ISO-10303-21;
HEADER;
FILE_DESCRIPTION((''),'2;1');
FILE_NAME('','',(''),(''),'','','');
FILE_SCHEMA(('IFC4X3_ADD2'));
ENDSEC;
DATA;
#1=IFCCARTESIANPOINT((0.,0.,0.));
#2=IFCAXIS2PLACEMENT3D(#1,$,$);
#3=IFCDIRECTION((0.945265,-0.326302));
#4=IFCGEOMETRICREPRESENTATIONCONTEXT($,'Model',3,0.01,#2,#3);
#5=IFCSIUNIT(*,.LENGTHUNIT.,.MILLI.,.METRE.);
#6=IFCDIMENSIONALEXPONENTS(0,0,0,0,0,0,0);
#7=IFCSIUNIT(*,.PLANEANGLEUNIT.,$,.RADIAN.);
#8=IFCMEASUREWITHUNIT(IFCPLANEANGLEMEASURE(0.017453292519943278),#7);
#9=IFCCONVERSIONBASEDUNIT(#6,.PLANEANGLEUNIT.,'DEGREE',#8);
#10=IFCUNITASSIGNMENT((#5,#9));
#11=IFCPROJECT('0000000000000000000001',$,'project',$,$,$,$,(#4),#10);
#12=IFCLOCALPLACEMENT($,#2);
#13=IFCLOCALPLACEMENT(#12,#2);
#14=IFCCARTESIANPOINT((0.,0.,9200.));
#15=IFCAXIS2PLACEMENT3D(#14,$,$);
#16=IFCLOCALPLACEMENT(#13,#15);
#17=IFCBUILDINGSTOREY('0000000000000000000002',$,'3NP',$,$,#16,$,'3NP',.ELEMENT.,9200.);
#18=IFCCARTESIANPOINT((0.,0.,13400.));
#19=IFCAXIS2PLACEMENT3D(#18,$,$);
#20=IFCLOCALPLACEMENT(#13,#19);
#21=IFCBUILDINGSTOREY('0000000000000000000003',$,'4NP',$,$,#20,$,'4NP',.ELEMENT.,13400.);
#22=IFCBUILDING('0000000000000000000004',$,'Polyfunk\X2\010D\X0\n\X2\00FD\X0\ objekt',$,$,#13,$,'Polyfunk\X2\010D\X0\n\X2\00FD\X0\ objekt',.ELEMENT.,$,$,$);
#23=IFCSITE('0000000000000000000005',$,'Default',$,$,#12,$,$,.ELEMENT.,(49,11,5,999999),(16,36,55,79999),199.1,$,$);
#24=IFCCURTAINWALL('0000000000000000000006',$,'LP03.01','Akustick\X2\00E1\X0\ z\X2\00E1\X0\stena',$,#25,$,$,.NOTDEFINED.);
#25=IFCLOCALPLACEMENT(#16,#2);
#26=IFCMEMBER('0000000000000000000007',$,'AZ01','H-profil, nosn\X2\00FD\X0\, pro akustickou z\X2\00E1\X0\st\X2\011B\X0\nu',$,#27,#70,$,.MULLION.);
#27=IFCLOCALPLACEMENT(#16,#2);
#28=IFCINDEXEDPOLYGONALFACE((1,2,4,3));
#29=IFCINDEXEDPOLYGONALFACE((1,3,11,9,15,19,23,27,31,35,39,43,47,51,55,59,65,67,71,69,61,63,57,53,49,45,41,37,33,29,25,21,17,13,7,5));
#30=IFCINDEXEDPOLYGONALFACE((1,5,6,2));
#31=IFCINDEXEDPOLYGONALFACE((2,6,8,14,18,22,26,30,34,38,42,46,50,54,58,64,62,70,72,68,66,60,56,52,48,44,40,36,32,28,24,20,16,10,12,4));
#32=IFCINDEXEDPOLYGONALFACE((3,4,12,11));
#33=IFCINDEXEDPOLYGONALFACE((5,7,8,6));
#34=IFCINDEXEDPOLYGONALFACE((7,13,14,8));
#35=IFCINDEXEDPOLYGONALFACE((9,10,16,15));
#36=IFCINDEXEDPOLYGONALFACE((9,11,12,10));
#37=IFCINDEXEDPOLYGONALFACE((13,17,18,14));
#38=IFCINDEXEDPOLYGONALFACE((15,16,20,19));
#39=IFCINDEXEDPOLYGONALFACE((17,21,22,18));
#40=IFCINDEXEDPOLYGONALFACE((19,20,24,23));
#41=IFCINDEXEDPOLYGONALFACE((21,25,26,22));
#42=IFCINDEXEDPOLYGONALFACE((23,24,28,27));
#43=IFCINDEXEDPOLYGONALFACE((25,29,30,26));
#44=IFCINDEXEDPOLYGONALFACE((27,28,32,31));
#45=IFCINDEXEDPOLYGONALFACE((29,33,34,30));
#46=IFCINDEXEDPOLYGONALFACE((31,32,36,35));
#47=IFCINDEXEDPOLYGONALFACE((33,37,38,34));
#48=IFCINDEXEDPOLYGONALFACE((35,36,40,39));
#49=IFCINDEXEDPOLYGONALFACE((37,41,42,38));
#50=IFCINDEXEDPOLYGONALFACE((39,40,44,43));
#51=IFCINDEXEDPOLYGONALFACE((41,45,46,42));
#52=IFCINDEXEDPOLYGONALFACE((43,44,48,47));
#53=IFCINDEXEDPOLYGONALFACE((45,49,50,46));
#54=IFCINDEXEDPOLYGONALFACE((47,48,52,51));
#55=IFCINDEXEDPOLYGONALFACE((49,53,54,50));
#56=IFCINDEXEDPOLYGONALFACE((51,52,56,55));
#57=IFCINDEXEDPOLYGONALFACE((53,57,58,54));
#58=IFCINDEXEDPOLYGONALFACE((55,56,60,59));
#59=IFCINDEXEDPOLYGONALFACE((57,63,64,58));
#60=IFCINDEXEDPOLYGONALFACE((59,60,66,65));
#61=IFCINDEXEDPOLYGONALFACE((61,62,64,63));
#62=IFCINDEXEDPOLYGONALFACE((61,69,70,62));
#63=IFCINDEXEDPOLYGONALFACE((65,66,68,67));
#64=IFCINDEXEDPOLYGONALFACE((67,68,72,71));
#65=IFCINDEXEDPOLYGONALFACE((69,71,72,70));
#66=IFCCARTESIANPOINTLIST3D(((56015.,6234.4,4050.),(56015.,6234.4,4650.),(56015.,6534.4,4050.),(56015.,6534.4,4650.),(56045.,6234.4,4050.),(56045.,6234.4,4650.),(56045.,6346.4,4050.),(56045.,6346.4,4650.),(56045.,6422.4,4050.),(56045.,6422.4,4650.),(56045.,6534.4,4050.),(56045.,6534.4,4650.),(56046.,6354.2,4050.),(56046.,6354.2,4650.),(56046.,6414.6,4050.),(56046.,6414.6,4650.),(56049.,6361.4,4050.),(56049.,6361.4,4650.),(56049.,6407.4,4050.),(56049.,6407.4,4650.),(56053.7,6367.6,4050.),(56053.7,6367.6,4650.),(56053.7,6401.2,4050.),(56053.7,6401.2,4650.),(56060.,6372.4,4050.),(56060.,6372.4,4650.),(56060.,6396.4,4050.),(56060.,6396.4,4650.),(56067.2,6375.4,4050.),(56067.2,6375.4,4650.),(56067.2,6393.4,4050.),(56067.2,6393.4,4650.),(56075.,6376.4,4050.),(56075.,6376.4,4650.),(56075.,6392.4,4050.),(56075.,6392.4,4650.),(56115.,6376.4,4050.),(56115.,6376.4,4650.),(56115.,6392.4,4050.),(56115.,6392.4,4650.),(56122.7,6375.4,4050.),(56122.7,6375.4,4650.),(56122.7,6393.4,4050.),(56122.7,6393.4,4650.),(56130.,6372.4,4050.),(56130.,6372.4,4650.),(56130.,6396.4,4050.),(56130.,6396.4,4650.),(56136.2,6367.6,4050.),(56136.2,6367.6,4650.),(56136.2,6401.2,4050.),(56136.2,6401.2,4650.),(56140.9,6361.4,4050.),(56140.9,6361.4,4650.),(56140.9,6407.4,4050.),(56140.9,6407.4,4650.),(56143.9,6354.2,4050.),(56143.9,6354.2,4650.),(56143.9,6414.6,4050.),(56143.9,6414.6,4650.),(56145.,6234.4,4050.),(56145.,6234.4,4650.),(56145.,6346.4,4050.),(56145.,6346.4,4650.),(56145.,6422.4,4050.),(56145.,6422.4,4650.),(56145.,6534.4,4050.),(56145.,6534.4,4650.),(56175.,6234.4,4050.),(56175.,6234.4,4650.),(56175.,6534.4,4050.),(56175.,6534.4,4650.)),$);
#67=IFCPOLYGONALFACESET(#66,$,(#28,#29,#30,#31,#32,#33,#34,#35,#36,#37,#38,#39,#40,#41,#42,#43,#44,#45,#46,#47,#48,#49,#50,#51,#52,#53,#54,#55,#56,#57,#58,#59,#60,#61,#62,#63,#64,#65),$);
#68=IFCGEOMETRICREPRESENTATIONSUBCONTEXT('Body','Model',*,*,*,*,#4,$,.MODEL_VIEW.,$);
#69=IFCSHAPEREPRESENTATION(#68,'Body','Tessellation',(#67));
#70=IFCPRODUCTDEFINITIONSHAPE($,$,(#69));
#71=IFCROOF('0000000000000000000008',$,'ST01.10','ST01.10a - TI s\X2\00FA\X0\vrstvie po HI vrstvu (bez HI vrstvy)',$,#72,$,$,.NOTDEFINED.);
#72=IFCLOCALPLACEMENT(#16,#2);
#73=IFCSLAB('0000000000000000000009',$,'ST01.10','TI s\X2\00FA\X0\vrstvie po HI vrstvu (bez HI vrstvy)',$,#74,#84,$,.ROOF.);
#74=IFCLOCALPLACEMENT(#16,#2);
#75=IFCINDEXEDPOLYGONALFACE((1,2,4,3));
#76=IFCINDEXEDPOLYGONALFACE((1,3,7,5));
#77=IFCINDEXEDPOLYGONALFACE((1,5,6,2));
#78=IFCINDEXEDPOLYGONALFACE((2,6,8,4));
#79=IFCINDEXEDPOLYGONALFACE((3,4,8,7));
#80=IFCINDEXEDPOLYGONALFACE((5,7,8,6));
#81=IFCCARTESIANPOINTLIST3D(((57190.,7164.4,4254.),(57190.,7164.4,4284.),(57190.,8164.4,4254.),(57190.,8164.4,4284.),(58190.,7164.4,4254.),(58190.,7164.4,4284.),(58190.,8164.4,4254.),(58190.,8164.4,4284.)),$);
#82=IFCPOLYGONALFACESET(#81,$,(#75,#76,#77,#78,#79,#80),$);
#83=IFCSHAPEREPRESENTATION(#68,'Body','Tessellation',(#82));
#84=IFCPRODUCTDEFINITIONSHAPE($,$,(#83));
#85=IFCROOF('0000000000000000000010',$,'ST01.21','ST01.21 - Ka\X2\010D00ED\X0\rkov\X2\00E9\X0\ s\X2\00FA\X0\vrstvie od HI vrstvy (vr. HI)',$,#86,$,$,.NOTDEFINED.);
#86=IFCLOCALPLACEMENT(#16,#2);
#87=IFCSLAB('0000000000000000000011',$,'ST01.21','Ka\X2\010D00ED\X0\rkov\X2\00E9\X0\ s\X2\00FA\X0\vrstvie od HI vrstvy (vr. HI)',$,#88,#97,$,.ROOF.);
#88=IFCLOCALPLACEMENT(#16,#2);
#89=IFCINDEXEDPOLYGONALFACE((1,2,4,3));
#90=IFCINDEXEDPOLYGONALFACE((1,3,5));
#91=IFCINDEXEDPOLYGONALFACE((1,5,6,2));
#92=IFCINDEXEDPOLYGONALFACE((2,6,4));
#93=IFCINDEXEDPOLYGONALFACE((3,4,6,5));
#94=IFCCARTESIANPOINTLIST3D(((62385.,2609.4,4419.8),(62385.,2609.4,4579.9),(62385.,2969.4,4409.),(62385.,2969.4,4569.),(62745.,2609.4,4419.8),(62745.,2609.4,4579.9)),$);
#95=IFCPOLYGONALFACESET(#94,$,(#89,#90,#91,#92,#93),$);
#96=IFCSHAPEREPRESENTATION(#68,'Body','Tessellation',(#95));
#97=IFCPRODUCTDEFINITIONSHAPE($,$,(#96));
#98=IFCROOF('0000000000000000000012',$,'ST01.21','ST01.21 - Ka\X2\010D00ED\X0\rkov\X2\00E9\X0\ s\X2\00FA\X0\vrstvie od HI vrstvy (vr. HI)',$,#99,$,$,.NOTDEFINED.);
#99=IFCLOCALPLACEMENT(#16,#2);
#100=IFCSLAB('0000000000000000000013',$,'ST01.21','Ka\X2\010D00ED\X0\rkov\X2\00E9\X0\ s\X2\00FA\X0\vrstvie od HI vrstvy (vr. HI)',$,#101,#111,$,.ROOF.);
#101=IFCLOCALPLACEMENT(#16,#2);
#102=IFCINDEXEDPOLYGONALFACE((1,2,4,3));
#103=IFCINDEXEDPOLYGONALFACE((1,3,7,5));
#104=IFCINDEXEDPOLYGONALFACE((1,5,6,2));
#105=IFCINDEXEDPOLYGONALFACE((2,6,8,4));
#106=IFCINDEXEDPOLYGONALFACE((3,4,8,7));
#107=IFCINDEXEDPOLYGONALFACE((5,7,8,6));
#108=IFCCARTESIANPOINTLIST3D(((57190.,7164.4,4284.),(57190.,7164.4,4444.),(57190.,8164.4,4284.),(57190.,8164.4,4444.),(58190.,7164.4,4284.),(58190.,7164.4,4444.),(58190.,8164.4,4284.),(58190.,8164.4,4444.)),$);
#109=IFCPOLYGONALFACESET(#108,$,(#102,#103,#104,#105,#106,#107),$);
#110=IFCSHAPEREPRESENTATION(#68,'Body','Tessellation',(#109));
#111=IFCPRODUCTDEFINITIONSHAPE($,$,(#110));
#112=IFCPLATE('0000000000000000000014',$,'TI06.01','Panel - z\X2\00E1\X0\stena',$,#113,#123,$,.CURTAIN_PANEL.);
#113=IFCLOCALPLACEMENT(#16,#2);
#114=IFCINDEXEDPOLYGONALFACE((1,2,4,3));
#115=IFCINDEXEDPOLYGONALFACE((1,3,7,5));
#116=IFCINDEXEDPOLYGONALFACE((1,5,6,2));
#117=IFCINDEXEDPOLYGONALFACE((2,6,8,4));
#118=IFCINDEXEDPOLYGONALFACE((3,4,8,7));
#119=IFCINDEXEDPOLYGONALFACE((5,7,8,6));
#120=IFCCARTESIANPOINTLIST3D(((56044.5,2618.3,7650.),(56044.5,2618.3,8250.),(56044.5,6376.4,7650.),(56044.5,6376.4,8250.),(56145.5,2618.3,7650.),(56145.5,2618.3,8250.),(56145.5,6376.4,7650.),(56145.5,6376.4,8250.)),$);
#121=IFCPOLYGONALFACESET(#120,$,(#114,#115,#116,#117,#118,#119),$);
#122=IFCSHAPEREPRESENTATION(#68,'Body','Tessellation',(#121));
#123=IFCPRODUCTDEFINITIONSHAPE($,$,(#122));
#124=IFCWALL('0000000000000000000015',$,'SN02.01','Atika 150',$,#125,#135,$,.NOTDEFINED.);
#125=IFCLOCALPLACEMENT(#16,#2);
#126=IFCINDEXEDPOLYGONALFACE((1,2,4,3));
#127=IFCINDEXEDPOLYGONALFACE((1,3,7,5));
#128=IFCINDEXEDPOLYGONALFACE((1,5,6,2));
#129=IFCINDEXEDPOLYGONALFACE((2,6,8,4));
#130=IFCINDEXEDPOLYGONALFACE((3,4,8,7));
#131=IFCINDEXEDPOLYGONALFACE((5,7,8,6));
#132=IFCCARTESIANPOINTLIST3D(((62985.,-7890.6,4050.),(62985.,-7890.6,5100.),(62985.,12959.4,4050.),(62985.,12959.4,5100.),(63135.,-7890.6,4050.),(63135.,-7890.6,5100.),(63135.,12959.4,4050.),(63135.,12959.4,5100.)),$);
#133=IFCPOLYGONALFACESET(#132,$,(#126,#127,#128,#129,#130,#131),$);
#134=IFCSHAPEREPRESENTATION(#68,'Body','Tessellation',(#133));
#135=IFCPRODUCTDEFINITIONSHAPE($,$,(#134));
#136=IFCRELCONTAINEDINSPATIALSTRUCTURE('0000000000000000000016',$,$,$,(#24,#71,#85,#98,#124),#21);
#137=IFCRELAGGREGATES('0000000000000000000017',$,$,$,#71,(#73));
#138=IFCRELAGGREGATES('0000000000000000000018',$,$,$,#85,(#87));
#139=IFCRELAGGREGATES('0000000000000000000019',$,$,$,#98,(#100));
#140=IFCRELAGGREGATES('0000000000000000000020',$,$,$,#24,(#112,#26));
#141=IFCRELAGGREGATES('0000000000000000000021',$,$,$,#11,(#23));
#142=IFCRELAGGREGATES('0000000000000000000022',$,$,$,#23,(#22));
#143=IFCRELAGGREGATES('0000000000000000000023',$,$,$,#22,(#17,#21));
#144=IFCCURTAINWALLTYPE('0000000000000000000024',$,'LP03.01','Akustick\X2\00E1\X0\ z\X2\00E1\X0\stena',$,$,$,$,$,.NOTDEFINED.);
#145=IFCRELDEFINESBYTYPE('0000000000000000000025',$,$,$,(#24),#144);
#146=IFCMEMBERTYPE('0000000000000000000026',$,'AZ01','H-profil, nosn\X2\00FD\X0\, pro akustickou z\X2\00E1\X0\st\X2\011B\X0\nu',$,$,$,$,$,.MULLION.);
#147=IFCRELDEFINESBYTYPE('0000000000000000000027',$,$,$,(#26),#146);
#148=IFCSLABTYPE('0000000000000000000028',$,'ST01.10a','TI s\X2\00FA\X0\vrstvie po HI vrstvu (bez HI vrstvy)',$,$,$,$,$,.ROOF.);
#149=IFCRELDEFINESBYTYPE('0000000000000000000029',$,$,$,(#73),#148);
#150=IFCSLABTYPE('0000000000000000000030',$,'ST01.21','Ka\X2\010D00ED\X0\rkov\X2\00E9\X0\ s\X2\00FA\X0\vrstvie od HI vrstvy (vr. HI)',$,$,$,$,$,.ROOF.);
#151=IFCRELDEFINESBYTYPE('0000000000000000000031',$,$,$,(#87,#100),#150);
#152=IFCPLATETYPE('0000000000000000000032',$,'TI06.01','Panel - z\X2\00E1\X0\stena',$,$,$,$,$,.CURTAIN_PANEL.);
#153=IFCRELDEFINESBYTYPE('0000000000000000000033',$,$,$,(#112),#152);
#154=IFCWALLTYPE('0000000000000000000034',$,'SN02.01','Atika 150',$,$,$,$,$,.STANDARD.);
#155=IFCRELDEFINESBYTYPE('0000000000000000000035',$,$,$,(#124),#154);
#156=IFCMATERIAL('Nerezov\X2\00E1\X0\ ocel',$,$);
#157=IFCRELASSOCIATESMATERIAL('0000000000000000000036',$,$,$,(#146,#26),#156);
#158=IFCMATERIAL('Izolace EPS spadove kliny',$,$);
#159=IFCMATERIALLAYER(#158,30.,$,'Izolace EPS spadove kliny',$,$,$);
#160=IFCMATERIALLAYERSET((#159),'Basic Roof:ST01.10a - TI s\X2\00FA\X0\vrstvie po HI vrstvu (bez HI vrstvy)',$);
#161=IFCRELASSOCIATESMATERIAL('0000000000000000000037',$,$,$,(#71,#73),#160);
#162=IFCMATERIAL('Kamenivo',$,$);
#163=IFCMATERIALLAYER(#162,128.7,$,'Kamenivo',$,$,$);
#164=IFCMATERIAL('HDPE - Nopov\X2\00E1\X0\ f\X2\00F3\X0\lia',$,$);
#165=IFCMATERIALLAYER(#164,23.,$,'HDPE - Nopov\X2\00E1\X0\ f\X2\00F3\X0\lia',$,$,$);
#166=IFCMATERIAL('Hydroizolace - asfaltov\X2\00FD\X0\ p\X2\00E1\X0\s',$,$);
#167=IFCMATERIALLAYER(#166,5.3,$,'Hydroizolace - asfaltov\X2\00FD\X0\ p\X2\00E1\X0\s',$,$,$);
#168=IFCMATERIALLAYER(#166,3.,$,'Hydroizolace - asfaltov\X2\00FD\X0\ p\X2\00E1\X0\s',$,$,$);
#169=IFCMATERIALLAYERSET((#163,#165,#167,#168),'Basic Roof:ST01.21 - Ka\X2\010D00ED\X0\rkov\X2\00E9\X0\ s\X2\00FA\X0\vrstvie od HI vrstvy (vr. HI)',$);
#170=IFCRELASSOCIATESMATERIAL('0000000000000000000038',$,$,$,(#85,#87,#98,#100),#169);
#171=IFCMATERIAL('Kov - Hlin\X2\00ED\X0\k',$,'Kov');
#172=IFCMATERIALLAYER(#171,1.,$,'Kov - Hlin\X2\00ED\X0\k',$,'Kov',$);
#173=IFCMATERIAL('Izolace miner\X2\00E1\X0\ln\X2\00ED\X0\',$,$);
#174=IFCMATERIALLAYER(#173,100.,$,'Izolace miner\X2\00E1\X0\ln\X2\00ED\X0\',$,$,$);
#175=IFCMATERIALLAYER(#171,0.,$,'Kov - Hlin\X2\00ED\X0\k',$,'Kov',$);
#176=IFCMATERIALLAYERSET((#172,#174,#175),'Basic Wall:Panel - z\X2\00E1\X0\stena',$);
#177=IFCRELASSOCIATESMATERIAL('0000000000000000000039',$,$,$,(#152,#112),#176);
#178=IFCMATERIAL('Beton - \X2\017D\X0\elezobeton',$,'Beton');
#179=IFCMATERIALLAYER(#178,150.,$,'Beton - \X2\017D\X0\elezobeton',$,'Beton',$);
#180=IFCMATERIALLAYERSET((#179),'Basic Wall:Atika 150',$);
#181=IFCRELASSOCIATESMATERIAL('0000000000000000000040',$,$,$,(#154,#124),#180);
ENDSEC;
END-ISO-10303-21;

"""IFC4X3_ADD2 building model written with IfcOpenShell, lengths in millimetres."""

from ifc_helpers import new_model, entity, si_unit, converted_unit, direction, frame, frame_2d, origin, place, context, subcontext, project, spatial, polyline, circle_curve, parameter, trimmed, segment, composite_curve, rectangle, outline, extrude, source, transform, mapped, material, layer, layer_set, layer_usage, material_profile, profile_set, profile_usage, type_object, element, aggregate, save


model = new_model("IFC4X3_ADD2")

# Units and contexts
model_context = context("Model", 3, precision=0.01, world=origin(), true_north=direction((0.945265, -0.326302)))
body_context = subcontext(model_context, "Body", "Model", "MODEL_VIEW")
ifc_project = project(units=[si_unit("LENGTHUNIT", "METRE", prefix="MILLI"), converted_unit("PLANEANGLEUNIT", "DEGREE", entity("IfcPlaneAngleMeasure", 0.017453292519943278), si_unit("PLANEANGLEUNIT", "RADIAN"), dimensions=[0, 0, 0, 0, 0, 0, 0])], contexts=[model_context])

# Site, building, storey
site_placement = place(None, origin())
site = spatial("IfcSite", under=ifc_project, at=site_placement, Name="Default", CompositionType="ELEMENT", RefLatitude=(49, 11, 5, 999999), RefLongitude=(16, 36, 55, 79999), RefElevation=199.1)
building_placement = place(site_placement, origin())
building = spatial("IfcBuilding", under=site, at=building_placement, Name="Polyfunkčný objekt", LongName="Polyfunkčný objekt", CompositionType="ELEMENT")
storey_1_placement = place(building_placement, frame((0.0, 0.0, 9200.0)))
storey_1 = spatial("IfcBuildingStorey", under=building, at=storey_1_placement, Name="3NP", LongName="3NP", CompositionType="ELEMENT", Elevation=9200.0)

# Shared definitions
storey_2_placement = place(building_placement, frame((0.0, 0.0, 13400.0)))
storey_2 = spatial("IfcBuildingStorey", under=building, at=storey_2_placement, Name="4NP", LongName="4NP", CompositionType="ELEMENT", Elevation=13400.0)

# Curtain wall, member
curtain_wall_type_1 = type_object("IfcCurtainWallType", Name="LP03.01", Description="Akustická zástena", PredefinedType="NOTDEFINED")
ifc_material_1 = material(Name="Nerezová ocel")
ifc_material_profile_1 = material_profile(ifc_material_1, outline(composite_curve([segment(polyline([(50.0, -150.0), (80.0, -150.0)]), True, "CONTINUOUS"), segment(polyline([(80.0, -150.0), (80.0, 150.0)]), True, "CONTINUOUS"), segment(polyline([(80.0, 150.0), (50.0, 150.0)]), True, "CONTINUOUS"), segment(polyline([(50.0, 150.0), (50.0, 38.0)]), True, "CONTINUOUS"), segment(trimmed(circle_curve(frame_2d((20.0, 38.0), x_axis=(0.0, 1.0)), 30.0), [parameter(180.0)], [parameter(270.0)], True, "PARAMETER"), False, "CONTINUOUS"), segment(polyline([(20.0, 8.0), (-20.0, 8.0)]), True, "CONTINUOUS"), segment(trimmed(circle_curve(frame_2d((-20.0, 38.0), x_axis=(0.0, 1.0)), 30.0), [parameter(90.0)], [parameter(180.0)], True, "PARAMETER"), False, "CONTINUOUS"), segment(polyline([(-50.0, 38.0), (-50.0, 150.0)]), True, "CONTINUOUS"), segment(polyline([(-50.0, 150.0), (-80.0, 150.0)]), True, "CONTINUOUS"), segment(polyline([(-80.0, 150.0), (-80.0, -150.0)]), True, "CONTINUOUS"), segment(polyline([(-80.0, -150.0), (-50.0, -150.0)]), True, "CONTINUOUS"), segment(polyline([(-50.0, -150.0), (-50.0, -38.0)]), True, "CONTINUOUS"), segment(trimmed(circle_curve(frame_2d((-20.0, -38.0), x_axis=(0.0, 1.0)), 30.0), [parameter(0.0)], [parameter(90.0)], True, "PARAMETER"), False, "CONTINUOUS"), segment(polyline([(-20.0, -8.0), (20.0, -8.0)]), True, "CONTINUOUS"), segment(trimmed(circle_curve(frame_2d((20.0, -38.0), x_axis=(0.0, 1.0)), 30.0), [parameter(270.0)], [parameter(0.0)], True, "PARAMETER"), False, "CONTINUOUS"), segment(polyline([(50.0, -38.0), (50.0, -150.0)]), True, "CONTINUOUS")], self_intersect=False)), Name="Profil zástena")
ifc_profile_set_1 = profile_set([ifc_material_profile_1], Name="Profil zástena")
ifc_profile_usage_1 = profile_usage(ifc_profile_set_1)
member_type_1 = type_object("IfcMemberType", Name="AZ01", Description="H-profil, nosný, pro akustickou zástěnu", PredefinedType="MULLION", material=ifc_profile_set_1)
curtain_wall_1_placement = place(storey_2_placement, frame((0.0, 0.0, -13400.0)))
curtain_wall_1 = element("IfcCurtainWall", 1, at=curtain_wall_1_placement, inside=storey_2, type_object=curtain_wall_type_1, Name="LP03.01", Description="Akustická zástena", PredefinedType="NOTDEFINED")
shared_shape_1 = source(origin(), body_context, "Body", "SweptSolid", [
    extrude(outline(composite_curve([segment(polyline([(-150.0, -50.0), (-150.0, -80.0)]), True, "CONTINUOUS"), segment(polyline([(-150.0, -80.0), (150.0, -80.0)]), True, "CONTINUOUS"), segment(polyline([(150.0, -80.0), (150.0, -50.0)]), True, "CONTINUOUS"), segment(polyline([(150.0, -50.0), (38.0, -50.0)]), True, "CONTINUOUS"), segment(trimmed(circle_curve(frame_2d((38.0, -20.0), x_axis=(1.0, 0.0)), 30.0), [parameter(180.0)], [parameter(270.0)], True, "PARAMETER"), False, "CONTINUOUS"), segment(polyline([(8.0, -20.0), (8.0, 20.0)]), True, "CONTINUOUS"), segment(trimmed(circle_curve(frame_2d((38.0, 20.0), x_axis=(1.0, 0.0)), 30.0), [parameter(90.0)], [parameter(180.0)], True, "PARAMETER"), False, "CONTINUOUS"), segment(polyline([(38.0, 50.0), (150.0, 50.0)]), True, "CONTINUOUS"), segment(polyline([(150.0, 50.0), (150.0, 80.0)]), True, "CONTINUOUS"), segment(polyline([(150.0, 80.0), (-150.0, 80.0)]), True, "CONTINUOUS"), segment(polyline([(-150.0, 80.0), (-150.0, 50.0)]), True, "CONTINUOUS"), segment(polyline([(-150.0, 50.0), (-38.0, 50.0)]), True, "CONTINUOUS"), segment(trimmed(circle_curve(frame_2d((-38.0, 20.0), x_axis=(1.0, 0.0)), 30.0), [parameter(0.0)], [parameter(90.0)], True, "PARAMETER"), False, "CONTINUOUS"), segment(polyline([(-8.0, 20.0), (-8.0, -20.0)]), True, "CONTINUOUS"), segment(trimmed(circle_curve(frame_2d((-38.0, -20.0), x_axis=(1.0, 0.0)), 30.0), [parameter(270.0)], [parameter(0.0)], True, "PARAMETER"), False, "CONTINUOUS"), segment(polyline([(-38.0, -50.0), (-150.0, -50.0)]), True, "CONTINUOUS")], self_intersect=False)), frame((-150.0, 0.0, -600.0), z_axis=(0.0, 0.0, -1.0), x_axis=(1.0, 0.0, 0.0)), (0.0, 0.0, -1.0), 600.0),
])
member_1_placement = place(curtain_wall_1_placement, frame((56095.0, 6534.4, 13250.0), z_axis=(0.0, 0.0, -1.0), x_axis=(0.0, 1.0, 0.0)))
member_1 = element("IfcMember", 2, at=member_1_placement, type_object=member_type_1, material=ifc_profile_usage_1, Name="AZ01", Description="H-profil, nosný, pro akustickou zástěnu", PredefinedType="MULLION", context=body_context, shape_type="MappedRepresentation", body=[
    mapped(shared_shape_1, transform((0.0, 0.0, 0.0), scale=1.0)),
])

# Roofs, slabs
ifc_material_2 = material(Name="Izolace EPS spadove kliny")
ifc_layer_1 = layer(ifc_material_2, 30.0, Name="Izolace EPS spadove kliny")
ifc_layer_set_1 = layer_set([ifc_layer_1], Name="Basic Roof:ST01.10a - TI súvrstvie po HI vrstvu (bez HI vrstvy)")
roof_1_placement = place(storey_2_placement, frame((57190.0, 7164.4, 54.0)))
roof_1 = element("IfcRoof", 3, at=roof_1_placement, inside=storey_2, material=ifc_layer_set_1, Name="ST01.10", Description="ST01.10a - TI súvrstvie po HI vrstvu (bez HI vrstvy)", PredefinedType="NOTDEFINED")
slab_type_1 = type_object("IfcSlabType", Name="ST01.10a", Description="TI súvrstvie po HI vrstvu (bez HI vrstvy)", PredefinedType="ROOF")
slab_1_placement = place(roof_1_placement, origin())
slab_1 = element("IfcSlab", 4, at=slab_1_placement, type_object=slab_type_1, material=ifc_layer_set_1, Name="ST01.10", Description="TI súvrstvie po HI vrstvu (bez HI vrstvy)", PredefinedType="ROOF", context=body_context, shape_type="SweptSolid", body=[
    extrude(rectangle(XDim=1000.0, YDim=1000.0, at=frame_2d((0.0, 0.0), x_axis=(1.0, 0.0))), frame((500.0, 500.0, 0.0)), (0.0, 0.0, 1.0), 30.0),
])
aggregate(roof_1, [slab_1])
ifc_material_3 = material(Name="Kamenivo")
ifc_layer_2 = layer(ifc_material_3, 128.7, Name="Kamenivo")
ifc_material_4 = material(Name="HDPE - Nopová fólia")
ifc_layer_3 = layer(ifc_material_4, 23.0, Name="HDPE - Nopová fólia")
ifc_material_5 = material(Name="Hydroizolace - asfaltový pás")
ifc_layer_4 = layer(ifc_material_5, 5.3, Name="Hydroizolace - asfaltový pás")
ifc_layer_5 = layer(ifc_material_5, 3.0, Name="Hydroizolace - asfaltový pás")
ifc_layer_set_2 = layer_set([ifc_layer_2, ifc_layer_3, ifc_layer_4, ifc_layer_5], Name="Basic Roof:ST01.21 - Kačírkové súvrstvie od HI vrstvy (vr. HI)")
roof_2_placement = place(storey_2_placement, frame((62385.0, 2609.4, 209.0)))
roof_2 = element("IfcRoof", 5, at=roof_2_placement, inside=storey_2, material=ifc_layer_set_2, Name="ST01.21", Description="ST01.21 - Kačírkové súvrstvie od HI vrstvy (vr. HI)", PredefinedType="NOTDEFINED")
slab_type_2 = type_object("IfcSlabType", Name="ST01.21", Description="Kačírkové súvrstvie od HI vrstvy (vr. HI)", PredefinedType="ROOF")
slab_2_placement = place(roof_2_placement, origin())
slab_2 = element("IfcSlab", 6, at=slab_2_placement, type_object=slab_type_2, material=ifc_layer_set_2, Name="ST01.21", Description="Kačírkové súvrstvie od HI vrstvy (vr. HI)", PredefinedType="ROOF", context=body_context, shape_type="SweptSolid", body=[
    extrude(outline(polyline([(180.0, -180.1), (-180.0, 180.1), (-180.0, -180.1), (180.0, -180.1)])), frame((180.0, 180.0, 5.4), z_axis=(0.0, 0.030015, 0.999549), x_axis=(1.0, 0.0, 0.0)), (0.0, -0.030015, 0.999549), 160.1),
])
aggregate(roof_2, [slab_2])
roof_3_placement = place(storey_2_placement, frame((57190.0, 7164.4, 84.0)))
roof_3 = element("IfcRoof", 7, at=roof_3_placement, inside=storey_2, material=ifc_layer_set_2, Name="ST01.21", Description="ST01.21 - Kačírkové súvrstvie od HI vrstvy (vr. HI)", PredefinedType="NOTDEFINED")
slab_3_placement = place(roof_3_placement, origin())
slab_3 = element("IfcSlab", 8, at=slab_3_placement, type_object=slab_type_2, material=ifc_layer_set_2, Name="ST01.21", Description="Kačírkové súvrstvie od HI vrstvy (vr. HI)", PredefinedType="ROOF", context=body_context, shape_type="SweptSolid", body=[
    extrude(rectangle(XDim=1000.0, YDim=1000.0, at=frame_2d((0.0, 0.0), x_axis=(1.0, 0.0))), frame((500.0, 500.0, 0.0)), (0.0, 0.0, 1.0), 160.0),
])
aggregate(roof_3, [slab_3])

# Plate
ifc_material_6 = material(Name="Kov - Hliník", Category="Kov")
ifc_layer_6 = layer(ifc_material_6, 1.0, Name="Kov - Hliník", Category="Kov")
ifc_material_7 = material(Name="Izolace minerální")
ifc_layer_7 = layer(ifc_material_7, 100.0, Name="Izolace minerální")
ifc_layer_8 = layer(ifc_material_6, 0.0, Name="Kov - Hliník", Category="Kov")
ifc_layer_set_3 = layer_set([ifc_layer_6, ifc_layer_7, ifc_layer_8], Name="Basic Wall:Panel - zástena")
ifc_layer_usage = layer_usage(ifc_layer_set_3, "AXIS2", "NEGATIVE", 50.5)
plate_type = type_object("IfcPlateType", Name="TI06.01", Description="Panel - zástena", PredefinedType="CURTAIN_PANEL", material=ifc_layer_set_3)
plate_placement = place(storey_2_placement, frame((56095.0, 2618.3, 3450.0), z_axis=(0.0, 0.0, 1.0), x_axis=(0.0, 1.0, 0.0)))
plate = element("IfcPlate", 9, at=plate_placement, type_object=plate_type, material=ifc_layer_usage, Name="TI06.01", Description="Panel - zástena", PredefinedType="CURTAIN_PANEL", context=body_context, shape_type="SweptSolid", body=[
    extrude(rectangle(XDim=101.0, YDim=3758.1, at=frame_2d((0.0, 0.0), x_axis=(1.0, 0.0))), frame((1879.0, 0.0, 0.0), z_axis=(0.0, 0.0, 1.0), x_axis=(0.0, 1.0, 0.0)), (0.0, 0.0, 1.0), 600.0),
])
aggregate(curtain_wall_1, [plate, member_1])

# Wall
ifc_material_8 = material(Name="Beton - Železobeton", Category="Beton")
ifc_layer_9 = layer(ifc_material_8, 150.0, Name="Beton - Železobeton", Category="Beton")
ifc_layer_set_4 = layer_set([ifc_layer_9], Name="Basic Wall:Atika 150")
wall_type = type_object("IfcWallType", Name="SN02.01", Description="Atika 150", PredefinedType="STANDARD", material=ifc_layer_set_4)
wall_placement = place(storey_2_placement, frame((63060.0, 12959.4, -150.0), z_axis=(0.0, 0.0, 1.0), x_axis=(0.0, -1.0, 0.0)))
element("IfcWall", 10, at=wall_placement, inside=storey_2, type_object=wall_type, material=ifc_layer_set_4, Name="SN02.01", Description="Atika 150", PredefinedType="NOTDEFINED", context=body_context, shape_type="SweptSolid", body=[
    extrude(rectangle(XDim=20850.0, YDim=150.0, at=frame_2d((10425.0, 0.0), x_axis=(-1.0, 0.0))), origin(), (0.0, 0.0, 1.0), 1050.0),
])

save(model, "model.ifc")
